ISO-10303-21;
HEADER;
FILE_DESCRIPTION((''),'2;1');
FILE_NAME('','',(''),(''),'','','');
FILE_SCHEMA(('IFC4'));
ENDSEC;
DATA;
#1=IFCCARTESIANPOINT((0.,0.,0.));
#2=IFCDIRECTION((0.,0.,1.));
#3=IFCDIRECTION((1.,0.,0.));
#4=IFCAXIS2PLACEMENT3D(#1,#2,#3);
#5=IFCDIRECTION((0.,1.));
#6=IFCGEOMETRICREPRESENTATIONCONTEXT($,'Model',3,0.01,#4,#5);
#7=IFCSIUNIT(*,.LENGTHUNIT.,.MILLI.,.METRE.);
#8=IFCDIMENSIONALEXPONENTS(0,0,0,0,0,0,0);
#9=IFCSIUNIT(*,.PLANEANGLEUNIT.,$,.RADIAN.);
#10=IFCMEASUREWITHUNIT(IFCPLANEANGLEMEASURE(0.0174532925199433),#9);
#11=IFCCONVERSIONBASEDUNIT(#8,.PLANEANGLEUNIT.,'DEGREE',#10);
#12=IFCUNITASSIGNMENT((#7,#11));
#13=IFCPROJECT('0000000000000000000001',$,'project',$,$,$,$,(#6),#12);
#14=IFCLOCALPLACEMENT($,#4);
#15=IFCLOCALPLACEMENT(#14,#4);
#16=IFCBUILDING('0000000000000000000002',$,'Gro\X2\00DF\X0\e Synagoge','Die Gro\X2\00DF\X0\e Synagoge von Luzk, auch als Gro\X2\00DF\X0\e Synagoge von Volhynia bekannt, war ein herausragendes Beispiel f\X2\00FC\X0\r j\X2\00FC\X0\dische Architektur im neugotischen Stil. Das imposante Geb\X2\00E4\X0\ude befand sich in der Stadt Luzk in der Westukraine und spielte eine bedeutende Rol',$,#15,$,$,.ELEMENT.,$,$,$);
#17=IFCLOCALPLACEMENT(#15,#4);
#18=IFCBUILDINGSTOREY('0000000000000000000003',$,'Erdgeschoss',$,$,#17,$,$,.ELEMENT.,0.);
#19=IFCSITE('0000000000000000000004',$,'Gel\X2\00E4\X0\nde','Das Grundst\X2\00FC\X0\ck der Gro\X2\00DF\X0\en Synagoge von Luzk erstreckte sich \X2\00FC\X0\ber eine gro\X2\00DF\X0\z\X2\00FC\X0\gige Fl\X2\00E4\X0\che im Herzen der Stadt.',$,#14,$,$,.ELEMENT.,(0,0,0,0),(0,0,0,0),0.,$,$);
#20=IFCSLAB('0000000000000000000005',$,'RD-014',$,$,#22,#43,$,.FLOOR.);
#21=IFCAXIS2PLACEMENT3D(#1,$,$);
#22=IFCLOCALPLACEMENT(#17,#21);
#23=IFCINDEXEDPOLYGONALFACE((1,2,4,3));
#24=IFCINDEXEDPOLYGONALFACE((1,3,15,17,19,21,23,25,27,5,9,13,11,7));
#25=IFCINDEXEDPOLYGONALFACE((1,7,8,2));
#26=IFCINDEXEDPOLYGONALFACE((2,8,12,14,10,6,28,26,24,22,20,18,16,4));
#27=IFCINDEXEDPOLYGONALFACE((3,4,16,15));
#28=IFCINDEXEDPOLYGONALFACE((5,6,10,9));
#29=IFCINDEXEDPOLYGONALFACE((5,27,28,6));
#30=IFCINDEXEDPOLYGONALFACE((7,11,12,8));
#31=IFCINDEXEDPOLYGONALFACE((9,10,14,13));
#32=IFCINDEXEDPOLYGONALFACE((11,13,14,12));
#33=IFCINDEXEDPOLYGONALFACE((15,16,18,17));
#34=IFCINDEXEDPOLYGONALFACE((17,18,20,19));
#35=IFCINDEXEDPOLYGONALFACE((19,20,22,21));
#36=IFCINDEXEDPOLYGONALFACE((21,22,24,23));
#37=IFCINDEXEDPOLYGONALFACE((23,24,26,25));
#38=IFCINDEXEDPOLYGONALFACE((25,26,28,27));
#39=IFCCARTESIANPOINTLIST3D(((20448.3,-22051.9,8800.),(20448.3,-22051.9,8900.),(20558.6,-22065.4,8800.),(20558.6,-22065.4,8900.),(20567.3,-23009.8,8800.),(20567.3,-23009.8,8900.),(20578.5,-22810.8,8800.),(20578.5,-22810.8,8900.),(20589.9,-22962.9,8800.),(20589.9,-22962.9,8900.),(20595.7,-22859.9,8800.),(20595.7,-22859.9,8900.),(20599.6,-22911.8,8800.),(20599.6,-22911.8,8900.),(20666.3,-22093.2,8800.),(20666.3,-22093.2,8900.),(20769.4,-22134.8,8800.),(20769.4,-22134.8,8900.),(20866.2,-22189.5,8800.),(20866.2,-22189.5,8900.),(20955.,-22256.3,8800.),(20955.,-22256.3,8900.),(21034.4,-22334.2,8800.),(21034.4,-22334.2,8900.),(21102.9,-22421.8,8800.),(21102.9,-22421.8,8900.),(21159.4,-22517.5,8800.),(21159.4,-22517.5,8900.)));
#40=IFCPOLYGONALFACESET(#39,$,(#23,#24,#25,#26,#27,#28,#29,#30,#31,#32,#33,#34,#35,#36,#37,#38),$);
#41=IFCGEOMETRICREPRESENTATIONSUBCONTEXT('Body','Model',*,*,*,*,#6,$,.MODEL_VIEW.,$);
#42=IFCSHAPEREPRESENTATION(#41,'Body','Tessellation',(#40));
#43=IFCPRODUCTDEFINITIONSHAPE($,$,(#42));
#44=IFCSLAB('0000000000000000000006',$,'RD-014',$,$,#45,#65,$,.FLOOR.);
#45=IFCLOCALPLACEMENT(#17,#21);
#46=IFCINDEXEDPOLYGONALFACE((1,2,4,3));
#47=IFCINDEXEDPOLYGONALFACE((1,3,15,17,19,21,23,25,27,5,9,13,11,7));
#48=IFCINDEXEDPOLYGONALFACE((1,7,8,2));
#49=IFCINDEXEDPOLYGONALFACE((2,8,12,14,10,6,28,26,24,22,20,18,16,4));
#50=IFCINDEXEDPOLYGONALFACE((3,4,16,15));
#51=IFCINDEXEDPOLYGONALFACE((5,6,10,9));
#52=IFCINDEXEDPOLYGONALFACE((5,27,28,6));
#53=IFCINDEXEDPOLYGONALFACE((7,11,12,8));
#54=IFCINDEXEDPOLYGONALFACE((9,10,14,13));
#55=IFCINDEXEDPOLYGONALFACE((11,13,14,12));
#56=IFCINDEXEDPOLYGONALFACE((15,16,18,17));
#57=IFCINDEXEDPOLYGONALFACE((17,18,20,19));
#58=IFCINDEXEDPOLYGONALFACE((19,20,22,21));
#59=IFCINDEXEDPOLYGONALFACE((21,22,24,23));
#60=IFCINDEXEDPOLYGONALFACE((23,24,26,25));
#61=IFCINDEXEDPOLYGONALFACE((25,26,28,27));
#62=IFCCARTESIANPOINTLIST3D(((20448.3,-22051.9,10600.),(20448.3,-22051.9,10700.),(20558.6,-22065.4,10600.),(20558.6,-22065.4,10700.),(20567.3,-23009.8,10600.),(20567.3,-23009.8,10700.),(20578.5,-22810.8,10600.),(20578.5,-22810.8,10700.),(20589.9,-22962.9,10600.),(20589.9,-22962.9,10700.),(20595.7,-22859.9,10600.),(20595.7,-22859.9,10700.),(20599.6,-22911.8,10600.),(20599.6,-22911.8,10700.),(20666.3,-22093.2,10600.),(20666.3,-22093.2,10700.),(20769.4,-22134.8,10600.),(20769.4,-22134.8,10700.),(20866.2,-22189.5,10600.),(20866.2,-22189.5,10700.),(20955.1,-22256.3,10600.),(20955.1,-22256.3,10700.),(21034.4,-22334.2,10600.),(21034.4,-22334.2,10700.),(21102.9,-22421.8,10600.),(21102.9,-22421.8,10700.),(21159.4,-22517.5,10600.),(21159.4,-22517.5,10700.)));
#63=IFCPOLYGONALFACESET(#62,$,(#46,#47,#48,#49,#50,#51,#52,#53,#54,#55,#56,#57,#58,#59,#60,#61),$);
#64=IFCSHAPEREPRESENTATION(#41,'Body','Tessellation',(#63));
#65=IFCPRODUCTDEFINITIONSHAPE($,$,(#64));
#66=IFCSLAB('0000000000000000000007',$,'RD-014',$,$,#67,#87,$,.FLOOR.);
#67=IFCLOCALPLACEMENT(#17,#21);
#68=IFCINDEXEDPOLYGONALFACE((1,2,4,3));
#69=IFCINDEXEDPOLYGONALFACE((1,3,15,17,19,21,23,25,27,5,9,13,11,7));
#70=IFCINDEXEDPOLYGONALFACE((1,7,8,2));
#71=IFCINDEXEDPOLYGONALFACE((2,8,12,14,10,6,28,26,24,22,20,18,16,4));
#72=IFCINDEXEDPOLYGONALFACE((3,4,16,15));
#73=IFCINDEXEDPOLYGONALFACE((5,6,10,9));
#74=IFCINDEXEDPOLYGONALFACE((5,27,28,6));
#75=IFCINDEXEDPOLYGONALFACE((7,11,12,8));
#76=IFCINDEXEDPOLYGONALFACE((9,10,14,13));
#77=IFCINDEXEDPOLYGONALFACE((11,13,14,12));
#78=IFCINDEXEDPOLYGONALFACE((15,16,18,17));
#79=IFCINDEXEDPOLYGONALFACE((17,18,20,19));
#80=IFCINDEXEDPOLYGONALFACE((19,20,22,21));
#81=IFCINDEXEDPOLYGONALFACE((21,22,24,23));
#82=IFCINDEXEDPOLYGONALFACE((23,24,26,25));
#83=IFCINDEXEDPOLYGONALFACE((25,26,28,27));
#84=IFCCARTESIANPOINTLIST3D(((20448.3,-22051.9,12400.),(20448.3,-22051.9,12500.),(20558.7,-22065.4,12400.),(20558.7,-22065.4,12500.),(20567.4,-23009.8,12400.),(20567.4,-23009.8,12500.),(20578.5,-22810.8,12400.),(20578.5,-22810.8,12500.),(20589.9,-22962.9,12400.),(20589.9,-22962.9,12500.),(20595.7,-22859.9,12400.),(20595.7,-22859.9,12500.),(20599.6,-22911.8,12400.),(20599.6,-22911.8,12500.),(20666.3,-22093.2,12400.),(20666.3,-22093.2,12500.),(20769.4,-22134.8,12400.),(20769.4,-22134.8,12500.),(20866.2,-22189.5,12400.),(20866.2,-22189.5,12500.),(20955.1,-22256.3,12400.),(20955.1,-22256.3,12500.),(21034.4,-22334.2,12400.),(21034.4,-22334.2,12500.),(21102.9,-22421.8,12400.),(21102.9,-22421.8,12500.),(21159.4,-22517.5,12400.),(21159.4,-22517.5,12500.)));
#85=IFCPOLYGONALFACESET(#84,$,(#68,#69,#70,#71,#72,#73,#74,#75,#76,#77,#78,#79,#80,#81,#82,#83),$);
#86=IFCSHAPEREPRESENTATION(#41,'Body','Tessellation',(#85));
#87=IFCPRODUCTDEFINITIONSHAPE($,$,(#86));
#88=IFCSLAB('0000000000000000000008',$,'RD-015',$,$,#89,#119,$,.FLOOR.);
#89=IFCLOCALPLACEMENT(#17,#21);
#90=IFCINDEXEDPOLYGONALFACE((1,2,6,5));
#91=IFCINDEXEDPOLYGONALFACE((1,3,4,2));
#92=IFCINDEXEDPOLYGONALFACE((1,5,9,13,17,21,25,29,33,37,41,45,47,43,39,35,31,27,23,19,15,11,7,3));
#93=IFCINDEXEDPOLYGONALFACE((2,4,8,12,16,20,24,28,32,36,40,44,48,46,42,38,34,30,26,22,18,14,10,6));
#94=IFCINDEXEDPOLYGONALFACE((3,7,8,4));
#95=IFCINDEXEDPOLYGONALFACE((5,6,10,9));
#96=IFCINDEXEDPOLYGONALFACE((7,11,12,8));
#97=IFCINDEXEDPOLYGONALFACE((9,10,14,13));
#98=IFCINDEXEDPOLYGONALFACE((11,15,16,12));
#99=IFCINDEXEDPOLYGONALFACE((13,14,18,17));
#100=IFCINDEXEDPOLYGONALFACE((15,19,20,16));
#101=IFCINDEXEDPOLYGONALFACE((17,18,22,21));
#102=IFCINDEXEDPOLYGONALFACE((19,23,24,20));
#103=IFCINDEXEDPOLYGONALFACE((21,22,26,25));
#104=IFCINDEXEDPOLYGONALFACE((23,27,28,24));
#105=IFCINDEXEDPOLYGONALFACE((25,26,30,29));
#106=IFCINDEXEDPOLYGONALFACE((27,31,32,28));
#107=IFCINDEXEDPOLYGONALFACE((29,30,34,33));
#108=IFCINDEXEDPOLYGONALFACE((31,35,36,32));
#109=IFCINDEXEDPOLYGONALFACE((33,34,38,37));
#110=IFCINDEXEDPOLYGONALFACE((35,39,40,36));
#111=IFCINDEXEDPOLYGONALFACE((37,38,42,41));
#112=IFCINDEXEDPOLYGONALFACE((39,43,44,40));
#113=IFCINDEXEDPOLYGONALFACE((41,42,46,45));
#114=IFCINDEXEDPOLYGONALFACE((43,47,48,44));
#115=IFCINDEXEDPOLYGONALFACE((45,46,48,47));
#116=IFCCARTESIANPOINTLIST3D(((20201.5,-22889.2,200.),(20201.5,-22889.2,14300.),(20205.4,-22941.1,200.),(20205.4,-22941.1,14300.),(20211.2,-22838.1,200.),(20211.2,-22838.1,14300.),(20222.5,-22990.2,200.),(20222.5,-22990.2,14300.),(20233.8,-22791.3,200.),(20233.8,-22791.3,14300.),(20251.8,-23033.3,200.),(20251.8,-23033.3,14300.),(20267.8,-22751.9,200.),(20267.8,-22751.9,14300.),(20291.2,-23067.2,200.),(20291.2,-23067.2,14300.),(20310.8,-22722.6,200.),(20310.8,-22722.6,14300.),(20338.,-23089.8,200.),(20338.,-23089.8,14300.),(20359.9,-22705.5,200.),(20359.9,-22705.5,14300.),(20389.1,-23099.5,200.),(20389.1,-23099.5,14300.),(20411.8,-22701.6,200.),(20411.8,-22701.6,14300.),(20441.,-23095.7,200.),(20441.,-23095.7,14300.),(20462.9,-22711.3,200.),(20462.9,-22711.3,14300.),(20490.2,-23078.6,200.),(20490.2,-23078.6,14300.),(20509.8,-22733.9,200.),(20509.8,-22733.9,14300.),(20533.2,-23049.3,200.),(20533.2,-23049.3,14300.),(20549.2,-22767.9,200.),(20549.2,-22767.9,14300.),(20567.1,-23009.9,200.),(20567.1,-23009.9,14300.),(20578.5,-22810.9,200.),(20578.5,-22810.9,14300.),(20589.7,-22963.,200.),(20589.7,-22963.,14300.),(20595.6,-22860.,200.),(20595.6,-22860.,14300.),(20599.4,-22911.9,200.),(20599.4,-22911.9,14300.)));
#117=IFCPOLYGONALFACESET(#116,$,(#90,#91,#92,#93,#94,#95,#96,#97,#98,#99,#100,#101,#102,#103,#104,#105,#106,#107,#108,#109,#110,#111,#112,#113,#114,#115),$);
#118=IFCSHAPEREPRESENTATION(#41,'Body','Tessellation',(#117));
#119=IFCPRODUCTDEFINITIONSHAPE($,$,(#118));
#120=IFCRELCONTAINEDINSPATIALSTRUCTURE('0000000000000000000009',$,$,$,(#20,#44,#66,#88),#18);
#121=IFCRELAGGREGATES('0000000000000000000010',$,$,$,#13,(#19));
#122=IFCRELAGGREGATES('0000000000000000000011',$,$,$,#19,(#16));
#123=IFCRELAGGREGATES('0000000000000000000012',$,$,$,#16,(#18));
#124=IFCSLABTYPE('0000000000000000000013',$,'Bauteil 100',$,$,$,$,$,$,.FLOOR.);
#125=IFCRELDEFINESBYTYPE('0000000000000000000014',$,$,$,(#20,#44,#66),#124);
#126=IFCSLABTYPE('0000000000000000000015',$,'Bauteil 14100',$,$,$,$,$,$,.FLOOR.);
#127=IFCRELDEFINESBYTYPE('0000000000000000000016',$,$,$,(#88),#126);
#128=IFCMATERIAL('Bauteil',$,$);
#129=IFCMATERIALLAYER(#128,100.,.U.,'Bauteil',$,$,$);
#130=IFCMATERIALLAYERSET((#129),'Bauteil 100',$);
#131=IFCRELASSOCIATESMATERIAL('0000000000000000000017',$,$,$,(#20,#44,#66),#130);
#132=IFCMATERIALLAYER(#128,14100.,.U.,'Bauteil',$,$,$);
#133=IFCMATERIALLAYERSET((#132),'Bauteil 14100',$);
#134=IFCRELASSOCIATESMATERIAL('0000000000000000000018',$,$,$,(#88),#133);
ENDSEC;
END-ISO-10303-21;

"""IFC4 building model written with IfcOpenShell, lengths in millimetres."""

from ifc_helpers import new_model, entity, si_unit, converted_unit, direction, frame, origin_with_axes, place, context, subcontext, project, spatial, line, arc, indexed_curve, outline, extrude, material, layer, layer_set, layer_usage, type_object, element, save


model = new_model("IFC4")

# Units and contexts
model_context = context("Model", 3, precision=0.01, world=origin_with_axes(), true_north=direction((0.0, 1.0)))
body_context = subcontext(model_context, "Body", "Model", "MODEL_VIEW")
ifc_project = project(units=[si_unit("LENGTHUNIT", "METRE", prefix="MILLI"), converted_unit("PLANEANGLEUNIT", "DEGREE", entity("IfcPlaneAngleMeasure", 0.0174532925199433), si_unit("PLANEANGLEUNIT", "RADIAN"), dimensions=[0, 0, 0, 0, 0, 0, 0])], contexts=[model_context])

# Site, building, storey
site_placement = place(None, origin_with_axes())
site = spatial("IfcSite", under=ifc_project, at=site_placement, Name="Gelände", Description="Das Grundstück der Großen Synagoge von Luzk erstreckte sich über eine großzügige Fläche im Herzen der Stadt.", CompositionType="ELEMENT", RefLatitude=(0, 0, 0, 0), RefLongitude=(0, 0, 0, 0), RefElevation=0.0)
building_placement = place(site_placement, origin_with_axes())
building = spatial("IfcBuilding", under=site, at=building_placement, Name="Große Synagoge", Description="Die Große Synagoge von Luzk, auch als Große Synagoge von Volhynia bekannt, war ein herausragendes Beispiel für jüdische Architektur im neugotischen Stil. Das imposante Gebäude befand sich in der Stadt Luzk in der Westukraine und spielte eine bedeutende Rol", CompositionType="ELEMENT")
storey_placement = place(building_placement, origin_with_axes())
storey = spatial("IfcBuildingStorey", under=building, at=storey_placement, Name="Erdgeschoss", CompositionType="ELEMENT", Elevation=0.0)

# Slabs
ifc_material = material(Name="Bauteil")
ifc_layer_1 = layer(ifc_material, 100.0, ventilated="UNKNOWN", Name="Bauteil")
ifc_layer_set_1 = layer_set([ifc_layer_1], Name="Bauteil 100")
slab_type_1 = type_object("IfcSlabType", Name="Bauteil 100", PredefinedType="FLOOR")
ifc_layer_usage_1 = layer_usage(ifc_layer_set_1, "AXIS3", "NEGATIVE", 100.0)
slab_1_placement = place(storey_placement, frame((21159.4, -22517.5, 8900.0), z_axis=(0.0, 0.0, 1.0), x_axis=(1.0, 0.0, 0.0)))
element("IfcSlab", 1, at=slab_1_placement, inside=storey, type_object=slab_type_1, material=ifc_layer_usage_1, Name="RD-014", PredefinedType="FLOOR", context=body_context, shape_type="SweptSolid", body=[
    extrude(outline(indexed_curve([(0.0, 0.0), (-293.2, 328.1), (-711.1, 465.6), (-580.9, -293.2), (-559.8, -394.2), (-592.1, -492.2)], segments=[arc(1, 2, 3), line(3, 4), arc(4, 5, 6), line(6, 1)])), frame((0.0, 0.0, -100.0), z_axis=(0.0, 0.0, 1.0), x_axis=(1.0, 0.0, 0.0)), (0.0, 0.0, 1.0), 100.0),
])
ifc_layer_usage_2 = layer_usage(ifc_layer_set_1, "AXIS3", "NEGATIVE", 100.0)
slab_2_placement = place(storey_placement, frame((21159.4, -22517.5, 10700.0), z_axis=(0.0, 0.0, 1.0), x_axis=(1.0, 0.0, 0.0)))
element("IfcSlab", 2, at=slab_2_placement, inside=storey, type_object=slab_type_1, material=ifc_layer_usage_2, Name="RD-014", PredefinedType="FLOOR", context=body_context, shape_type="SweptSolid", body=[
    extrude(outline(indexed_curve([(0.0, 0.0), (-293.2, 328.1), (-711.1, 465.6), (-580.9, -293.2), (-559.8, -394.2), (-592.1, -492.2)], segments=[arc(1, 2, 3), line(3, 4), arc(4, 5, 6), line(6, 1)])), frame((0.0, 0.0, -100.0), z_axis=(0.0, 0.0, 1.0), x_axis=(1.0, 0.0, 0.0)), (0.0, 0.0, 1.0), 100.0),
])
ifc_layer_usage_3 = layer_usage(ifc_layer_set_1, "AXIS3", "NEGATIVE", 100.0)
slab_3_placement = place(storey_placement, frame((21159.4, -22517.5, 12500.0), z_axis=(0.0, 0.0, 1.0), x_axis=(1.0, 0.0, 0.0)))
element("IfcSlab", 3, at=slab_3_placement, inside=storey, type_object=slab_type_1, material=ifc_layer_usage_3, Name="RD-014", PredefinedType="FLOOR", context=body_context, shape_type="SweptSolid", body=[
    extrude(outline(indexed_curve([(0.0, 0.0), (-293.2, 328.1), (-711.1, 465.6), (-580.9, -293.2), (-559.8, -394.2), (-592.1, -492.2)], segments=[arc(1, 2, 3), line(3, 4), arc(4, 5, 6), line(6, 1)])), frame((0.0, 0.0, -100.0), z_axis=(0.0, 0.0, 1.0), x_axis=(1.0, 0.0, 0.0)), (0.0, 0.0, 1.0), 100.0),
])
ifc_layer_2 = layer(ifc_material, 14100.0, ventilated="UNKNOWN", Name="Bauteil")
ifc_layer_set_2 = layer_set([ifc_layer_2], Name="Bauteil 14100")
ifc_layer_usage_4 = layer_usage(ifc_layer_set_2, "AXIS3", "NEGATIVE", 14100.0)
slab_type_2 = type_object("IfcSlabType", Name="Bauteil 14100", PredefinedType="FLOOR")
slab_4_placement = place(storey_placement, frame((20411.8, -22701.6, 14300.0), z_axis=(0.0, 0.0, 1.0), x_axis=(1.0, 0.0, 0.0)))
element("IfcSlab", 4, at=slab_4_placement, inside=storey, type_object=slab_type_2, material=ifc_layer_usage_4, Name="RD-015", PredefinedType="FLOOR", context=body_context, shape_type="SweptSolid", body=[
    extrude(outline(indexed_curve([(0.0, 0.0), (-210.3, -187.6), (-22.7, -397.9), (187.6, -210.3)], segments=[arc(1, 2, 3), arc(3, 4, 1)])), frame((0.0, 0.0, -14100.0), z_axis=(0.0, 0.0, 1.0), x_axis=(1.0, 0.0, 0.0)), (0.0, 0.0, 1.0), 14100.0),
])

save(model, "model.ifc")
